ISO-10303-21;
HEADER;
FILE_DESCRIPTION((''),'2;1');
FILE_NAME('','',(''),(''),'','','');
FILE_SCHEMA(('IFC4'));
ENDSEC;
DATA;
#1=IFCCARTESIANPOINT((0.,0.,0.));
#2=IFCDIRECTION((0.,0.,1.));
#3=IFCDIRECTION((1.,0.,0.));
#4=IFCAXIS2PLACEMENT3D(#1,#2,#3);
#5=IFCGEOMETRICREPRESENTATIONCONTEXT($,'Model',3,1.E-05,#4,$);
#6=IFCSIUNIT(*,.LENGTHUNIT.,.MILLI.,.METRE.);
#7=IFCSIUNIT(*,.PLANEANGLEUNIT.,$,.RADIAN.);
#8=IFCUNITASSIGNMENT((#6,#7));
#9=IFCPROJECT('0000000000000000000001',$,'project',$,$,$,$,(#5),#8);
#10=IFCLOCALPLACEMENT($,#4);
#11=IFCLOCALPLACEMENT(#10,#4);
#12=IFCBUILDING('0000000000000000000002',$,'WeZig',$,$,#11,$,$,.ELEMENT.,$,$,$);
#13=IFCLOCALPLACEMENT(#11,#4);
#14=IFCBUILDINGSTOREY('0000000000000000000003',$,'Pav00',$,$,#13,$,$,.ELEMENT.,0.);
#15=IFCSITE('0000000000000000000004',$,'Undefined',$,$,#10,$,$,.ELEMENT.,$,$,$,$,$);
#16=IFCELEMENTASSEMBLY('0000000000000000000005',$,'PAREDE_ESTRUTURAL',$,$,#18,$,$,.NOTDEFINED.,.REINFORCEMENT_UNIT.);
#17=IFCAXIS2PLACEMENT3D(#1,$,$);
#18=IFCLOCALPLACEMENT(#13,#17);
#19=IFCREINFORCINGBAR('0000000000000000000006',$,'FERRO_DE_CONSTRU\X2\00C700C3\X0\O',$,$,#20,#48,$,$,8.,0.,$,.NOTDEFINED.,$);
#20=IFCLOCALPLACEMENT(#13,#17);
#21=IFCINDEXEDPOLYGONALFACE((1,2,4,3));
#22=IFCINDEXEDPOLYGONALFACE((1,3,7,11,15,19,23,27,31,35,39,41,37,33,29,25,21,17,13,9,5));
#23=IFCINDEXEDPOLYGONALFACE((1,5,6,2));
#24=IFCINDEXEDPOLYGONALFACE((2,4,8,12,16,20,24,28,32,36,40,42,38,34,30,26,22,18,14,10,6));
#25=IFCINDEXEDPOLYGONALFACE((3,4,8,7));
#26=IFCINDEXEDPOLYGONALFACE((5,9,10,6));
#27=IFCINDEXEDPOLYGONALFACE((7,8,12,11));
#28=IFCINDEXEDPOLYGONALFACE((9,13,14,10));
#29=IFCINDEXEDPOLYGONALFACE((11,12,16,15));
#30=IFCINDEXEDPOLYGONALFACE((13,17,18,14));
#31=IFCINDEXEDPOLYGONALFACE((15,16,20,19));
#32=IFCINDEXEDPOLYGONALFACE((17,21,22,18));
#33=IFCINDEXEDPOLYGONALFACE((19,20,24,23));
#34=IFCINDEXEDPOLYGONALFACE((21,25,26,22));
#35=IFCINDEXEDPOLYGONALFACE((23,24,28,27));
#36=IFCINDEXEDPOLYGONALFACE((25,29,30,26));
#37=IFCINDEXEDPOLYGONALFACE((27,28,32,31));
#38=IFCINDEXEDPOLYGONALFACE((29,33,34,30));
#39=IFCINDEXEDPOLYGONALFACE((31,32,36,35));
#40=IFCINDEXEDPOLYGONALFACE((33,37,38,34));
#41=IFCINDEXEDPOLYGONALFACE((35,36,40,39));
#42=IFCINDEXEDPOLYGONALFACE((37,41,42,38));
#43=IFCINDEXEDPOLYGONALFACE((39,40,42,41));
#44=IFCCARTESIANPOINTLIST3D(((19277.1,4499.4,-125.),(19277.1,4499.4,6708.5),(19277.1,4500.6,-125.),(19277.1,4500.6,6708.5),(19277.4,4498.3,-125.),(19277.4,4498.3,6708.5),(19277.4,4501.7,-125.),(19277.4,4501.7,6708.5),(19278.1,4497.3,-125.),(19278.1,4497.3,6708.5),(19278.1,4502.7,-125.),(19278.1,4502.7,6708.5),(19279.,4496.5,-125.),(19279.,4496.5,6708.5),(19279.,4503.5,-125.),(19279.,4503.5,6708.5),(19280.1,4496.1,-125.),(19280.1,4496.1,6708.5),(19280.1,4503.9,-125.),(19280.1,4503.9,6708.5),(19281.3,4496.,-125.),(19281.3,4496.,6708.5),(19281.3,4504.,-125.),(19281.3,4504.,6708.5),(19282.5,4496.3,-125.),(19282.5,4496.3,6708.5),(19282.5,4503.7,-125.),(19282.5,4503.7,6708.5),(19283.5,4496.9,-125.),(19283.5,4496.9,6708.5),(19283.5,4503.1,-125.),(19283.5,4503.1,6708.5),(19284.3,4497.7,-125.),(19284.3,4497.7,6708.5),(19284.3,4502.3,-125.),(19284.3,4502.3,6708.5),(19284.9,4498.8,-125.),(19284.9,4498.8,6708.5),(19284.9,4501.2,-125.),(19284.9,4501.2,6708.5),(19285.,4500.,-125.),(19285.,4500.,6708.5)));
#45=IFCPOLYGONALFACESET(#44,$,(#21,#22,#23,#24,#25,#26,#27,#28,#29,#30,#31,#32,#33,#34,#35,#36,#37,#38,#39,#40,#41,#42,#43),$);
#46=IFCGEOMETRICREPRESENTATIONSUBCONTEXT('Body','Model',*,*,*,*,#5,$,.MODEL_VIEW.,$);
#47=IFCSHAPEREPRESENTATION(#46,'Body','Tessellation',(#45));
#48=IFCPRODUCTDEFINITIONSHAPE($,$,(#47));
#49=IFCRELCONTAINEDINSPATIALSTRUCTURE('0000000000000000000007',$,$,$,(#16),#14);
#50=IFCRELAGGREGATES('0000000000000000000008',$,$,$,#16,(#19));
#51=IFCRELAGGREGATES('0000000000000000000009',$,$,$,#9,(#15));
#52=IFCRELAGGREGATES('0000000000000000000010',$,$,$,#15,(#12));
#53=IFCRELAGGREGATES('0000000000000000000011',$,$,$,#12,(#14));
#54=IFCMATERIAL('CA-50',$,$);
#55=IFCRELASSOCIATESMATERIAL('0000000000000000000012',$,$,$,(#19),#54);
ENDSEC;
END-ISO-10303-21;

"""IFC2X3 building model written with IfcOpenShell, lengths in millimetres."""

from ifc_helpers import new_model, entity, si_unit, frame, origin_with_axes, place, context, subcontext, project, spatial, source, transform, mapped, material, element, aggregate, save


model = new_model("IFC2X3")

# Units and contexts
model_context = context("Model", 3, precision=1e-05, world=origin_with_axes())
body_context = subcontext(model_context, "Body", "Model", "MODEL_VIEW")
ifc_project = project(units=[si_unit("LENGTHUNIT", "METRE", prefix="MILLI"), si_unit("PLANEANGLEUNIT", "RADIAN")], contexts=[model_context])

# Site, building, storey
site_placement = place(None, origin_with_axes())
site = spatial("IfcSite", under=ifc_project, at=site_placement, Name="Undefined", CompositionType="ELEMENT")
building_placement = place(site_placement, origin_with_axes())
building = spatial("IfcBuilding", under=site, at=building_placement, Name="WeZig", CompositionType="ELEMENT")
storey_placement = place(building_placement, origin_with_axes())
storey = spatial("IfcBuildingStorey", under=building, at=storey_placement, Name="Pav00", CompositionType="ELEMENT", Elevation=0.0)

# Shared definitions
ifc_material_1 = material(Name="CA-50")

# Element assembly, reinforcing bar
assembly_1_placement = place(storey_placement, origin_with_axes())
assembly_1 = element("IfcElementAssembly", 1, at=assembly_1_placement, inside=storey, Name="PAREDE_ESTRUTURAL", AssemblyPlace="NOTDEFINED", PredefinedType="REINFORCEMENT_UNIT")
shared_shape_1 = source(origin_with_axes(), body_context, "Body", "AdvancedSweptSolid", [
    entity("IfcSweptDiskSolid", entity("IfcTrimmedCurve", entity("IfcLine", entity("IfcCartesianPoint", [0.0, 0.0, 0.0]), entity("IfcVector", entity("IfcDirection", [1.0, 0.0, 0.0]), 1.0)), [entity("IfcParameterValue", 0.0)], [entity("IfcParameterValue", 6833.500084)], True, "PARAMETER"), 4.0, None, 0.0, 6833.5),
])
reinforcing_bar_1_placement = place(assembly_1_placement, frame((19281.0, 4500.0, 6708.5), z_axis=(1.0, 0.0, 0.0), x_axis=(0.0, 0.0, -1.0)))
reinforcing_bar_1 = element("IfcReinforcingBar", 2, at=reinforcing_bar_1_placement, material=ifc_material_1, Name="FERRO_DE_CONSTRUÇÃO", BarRole="NOTDEFINED", CrossSectionArea=0.0, NominalDiameter=8.0, context=body_context, shape_type="MappedRepresentation", body=[
    mapped(shared_shape_1, transform((0.0, 0.0, 0.0))),
])
aggregate(assembly_1, [reinforcing_bar_1])

save(model, "model.ifc")
